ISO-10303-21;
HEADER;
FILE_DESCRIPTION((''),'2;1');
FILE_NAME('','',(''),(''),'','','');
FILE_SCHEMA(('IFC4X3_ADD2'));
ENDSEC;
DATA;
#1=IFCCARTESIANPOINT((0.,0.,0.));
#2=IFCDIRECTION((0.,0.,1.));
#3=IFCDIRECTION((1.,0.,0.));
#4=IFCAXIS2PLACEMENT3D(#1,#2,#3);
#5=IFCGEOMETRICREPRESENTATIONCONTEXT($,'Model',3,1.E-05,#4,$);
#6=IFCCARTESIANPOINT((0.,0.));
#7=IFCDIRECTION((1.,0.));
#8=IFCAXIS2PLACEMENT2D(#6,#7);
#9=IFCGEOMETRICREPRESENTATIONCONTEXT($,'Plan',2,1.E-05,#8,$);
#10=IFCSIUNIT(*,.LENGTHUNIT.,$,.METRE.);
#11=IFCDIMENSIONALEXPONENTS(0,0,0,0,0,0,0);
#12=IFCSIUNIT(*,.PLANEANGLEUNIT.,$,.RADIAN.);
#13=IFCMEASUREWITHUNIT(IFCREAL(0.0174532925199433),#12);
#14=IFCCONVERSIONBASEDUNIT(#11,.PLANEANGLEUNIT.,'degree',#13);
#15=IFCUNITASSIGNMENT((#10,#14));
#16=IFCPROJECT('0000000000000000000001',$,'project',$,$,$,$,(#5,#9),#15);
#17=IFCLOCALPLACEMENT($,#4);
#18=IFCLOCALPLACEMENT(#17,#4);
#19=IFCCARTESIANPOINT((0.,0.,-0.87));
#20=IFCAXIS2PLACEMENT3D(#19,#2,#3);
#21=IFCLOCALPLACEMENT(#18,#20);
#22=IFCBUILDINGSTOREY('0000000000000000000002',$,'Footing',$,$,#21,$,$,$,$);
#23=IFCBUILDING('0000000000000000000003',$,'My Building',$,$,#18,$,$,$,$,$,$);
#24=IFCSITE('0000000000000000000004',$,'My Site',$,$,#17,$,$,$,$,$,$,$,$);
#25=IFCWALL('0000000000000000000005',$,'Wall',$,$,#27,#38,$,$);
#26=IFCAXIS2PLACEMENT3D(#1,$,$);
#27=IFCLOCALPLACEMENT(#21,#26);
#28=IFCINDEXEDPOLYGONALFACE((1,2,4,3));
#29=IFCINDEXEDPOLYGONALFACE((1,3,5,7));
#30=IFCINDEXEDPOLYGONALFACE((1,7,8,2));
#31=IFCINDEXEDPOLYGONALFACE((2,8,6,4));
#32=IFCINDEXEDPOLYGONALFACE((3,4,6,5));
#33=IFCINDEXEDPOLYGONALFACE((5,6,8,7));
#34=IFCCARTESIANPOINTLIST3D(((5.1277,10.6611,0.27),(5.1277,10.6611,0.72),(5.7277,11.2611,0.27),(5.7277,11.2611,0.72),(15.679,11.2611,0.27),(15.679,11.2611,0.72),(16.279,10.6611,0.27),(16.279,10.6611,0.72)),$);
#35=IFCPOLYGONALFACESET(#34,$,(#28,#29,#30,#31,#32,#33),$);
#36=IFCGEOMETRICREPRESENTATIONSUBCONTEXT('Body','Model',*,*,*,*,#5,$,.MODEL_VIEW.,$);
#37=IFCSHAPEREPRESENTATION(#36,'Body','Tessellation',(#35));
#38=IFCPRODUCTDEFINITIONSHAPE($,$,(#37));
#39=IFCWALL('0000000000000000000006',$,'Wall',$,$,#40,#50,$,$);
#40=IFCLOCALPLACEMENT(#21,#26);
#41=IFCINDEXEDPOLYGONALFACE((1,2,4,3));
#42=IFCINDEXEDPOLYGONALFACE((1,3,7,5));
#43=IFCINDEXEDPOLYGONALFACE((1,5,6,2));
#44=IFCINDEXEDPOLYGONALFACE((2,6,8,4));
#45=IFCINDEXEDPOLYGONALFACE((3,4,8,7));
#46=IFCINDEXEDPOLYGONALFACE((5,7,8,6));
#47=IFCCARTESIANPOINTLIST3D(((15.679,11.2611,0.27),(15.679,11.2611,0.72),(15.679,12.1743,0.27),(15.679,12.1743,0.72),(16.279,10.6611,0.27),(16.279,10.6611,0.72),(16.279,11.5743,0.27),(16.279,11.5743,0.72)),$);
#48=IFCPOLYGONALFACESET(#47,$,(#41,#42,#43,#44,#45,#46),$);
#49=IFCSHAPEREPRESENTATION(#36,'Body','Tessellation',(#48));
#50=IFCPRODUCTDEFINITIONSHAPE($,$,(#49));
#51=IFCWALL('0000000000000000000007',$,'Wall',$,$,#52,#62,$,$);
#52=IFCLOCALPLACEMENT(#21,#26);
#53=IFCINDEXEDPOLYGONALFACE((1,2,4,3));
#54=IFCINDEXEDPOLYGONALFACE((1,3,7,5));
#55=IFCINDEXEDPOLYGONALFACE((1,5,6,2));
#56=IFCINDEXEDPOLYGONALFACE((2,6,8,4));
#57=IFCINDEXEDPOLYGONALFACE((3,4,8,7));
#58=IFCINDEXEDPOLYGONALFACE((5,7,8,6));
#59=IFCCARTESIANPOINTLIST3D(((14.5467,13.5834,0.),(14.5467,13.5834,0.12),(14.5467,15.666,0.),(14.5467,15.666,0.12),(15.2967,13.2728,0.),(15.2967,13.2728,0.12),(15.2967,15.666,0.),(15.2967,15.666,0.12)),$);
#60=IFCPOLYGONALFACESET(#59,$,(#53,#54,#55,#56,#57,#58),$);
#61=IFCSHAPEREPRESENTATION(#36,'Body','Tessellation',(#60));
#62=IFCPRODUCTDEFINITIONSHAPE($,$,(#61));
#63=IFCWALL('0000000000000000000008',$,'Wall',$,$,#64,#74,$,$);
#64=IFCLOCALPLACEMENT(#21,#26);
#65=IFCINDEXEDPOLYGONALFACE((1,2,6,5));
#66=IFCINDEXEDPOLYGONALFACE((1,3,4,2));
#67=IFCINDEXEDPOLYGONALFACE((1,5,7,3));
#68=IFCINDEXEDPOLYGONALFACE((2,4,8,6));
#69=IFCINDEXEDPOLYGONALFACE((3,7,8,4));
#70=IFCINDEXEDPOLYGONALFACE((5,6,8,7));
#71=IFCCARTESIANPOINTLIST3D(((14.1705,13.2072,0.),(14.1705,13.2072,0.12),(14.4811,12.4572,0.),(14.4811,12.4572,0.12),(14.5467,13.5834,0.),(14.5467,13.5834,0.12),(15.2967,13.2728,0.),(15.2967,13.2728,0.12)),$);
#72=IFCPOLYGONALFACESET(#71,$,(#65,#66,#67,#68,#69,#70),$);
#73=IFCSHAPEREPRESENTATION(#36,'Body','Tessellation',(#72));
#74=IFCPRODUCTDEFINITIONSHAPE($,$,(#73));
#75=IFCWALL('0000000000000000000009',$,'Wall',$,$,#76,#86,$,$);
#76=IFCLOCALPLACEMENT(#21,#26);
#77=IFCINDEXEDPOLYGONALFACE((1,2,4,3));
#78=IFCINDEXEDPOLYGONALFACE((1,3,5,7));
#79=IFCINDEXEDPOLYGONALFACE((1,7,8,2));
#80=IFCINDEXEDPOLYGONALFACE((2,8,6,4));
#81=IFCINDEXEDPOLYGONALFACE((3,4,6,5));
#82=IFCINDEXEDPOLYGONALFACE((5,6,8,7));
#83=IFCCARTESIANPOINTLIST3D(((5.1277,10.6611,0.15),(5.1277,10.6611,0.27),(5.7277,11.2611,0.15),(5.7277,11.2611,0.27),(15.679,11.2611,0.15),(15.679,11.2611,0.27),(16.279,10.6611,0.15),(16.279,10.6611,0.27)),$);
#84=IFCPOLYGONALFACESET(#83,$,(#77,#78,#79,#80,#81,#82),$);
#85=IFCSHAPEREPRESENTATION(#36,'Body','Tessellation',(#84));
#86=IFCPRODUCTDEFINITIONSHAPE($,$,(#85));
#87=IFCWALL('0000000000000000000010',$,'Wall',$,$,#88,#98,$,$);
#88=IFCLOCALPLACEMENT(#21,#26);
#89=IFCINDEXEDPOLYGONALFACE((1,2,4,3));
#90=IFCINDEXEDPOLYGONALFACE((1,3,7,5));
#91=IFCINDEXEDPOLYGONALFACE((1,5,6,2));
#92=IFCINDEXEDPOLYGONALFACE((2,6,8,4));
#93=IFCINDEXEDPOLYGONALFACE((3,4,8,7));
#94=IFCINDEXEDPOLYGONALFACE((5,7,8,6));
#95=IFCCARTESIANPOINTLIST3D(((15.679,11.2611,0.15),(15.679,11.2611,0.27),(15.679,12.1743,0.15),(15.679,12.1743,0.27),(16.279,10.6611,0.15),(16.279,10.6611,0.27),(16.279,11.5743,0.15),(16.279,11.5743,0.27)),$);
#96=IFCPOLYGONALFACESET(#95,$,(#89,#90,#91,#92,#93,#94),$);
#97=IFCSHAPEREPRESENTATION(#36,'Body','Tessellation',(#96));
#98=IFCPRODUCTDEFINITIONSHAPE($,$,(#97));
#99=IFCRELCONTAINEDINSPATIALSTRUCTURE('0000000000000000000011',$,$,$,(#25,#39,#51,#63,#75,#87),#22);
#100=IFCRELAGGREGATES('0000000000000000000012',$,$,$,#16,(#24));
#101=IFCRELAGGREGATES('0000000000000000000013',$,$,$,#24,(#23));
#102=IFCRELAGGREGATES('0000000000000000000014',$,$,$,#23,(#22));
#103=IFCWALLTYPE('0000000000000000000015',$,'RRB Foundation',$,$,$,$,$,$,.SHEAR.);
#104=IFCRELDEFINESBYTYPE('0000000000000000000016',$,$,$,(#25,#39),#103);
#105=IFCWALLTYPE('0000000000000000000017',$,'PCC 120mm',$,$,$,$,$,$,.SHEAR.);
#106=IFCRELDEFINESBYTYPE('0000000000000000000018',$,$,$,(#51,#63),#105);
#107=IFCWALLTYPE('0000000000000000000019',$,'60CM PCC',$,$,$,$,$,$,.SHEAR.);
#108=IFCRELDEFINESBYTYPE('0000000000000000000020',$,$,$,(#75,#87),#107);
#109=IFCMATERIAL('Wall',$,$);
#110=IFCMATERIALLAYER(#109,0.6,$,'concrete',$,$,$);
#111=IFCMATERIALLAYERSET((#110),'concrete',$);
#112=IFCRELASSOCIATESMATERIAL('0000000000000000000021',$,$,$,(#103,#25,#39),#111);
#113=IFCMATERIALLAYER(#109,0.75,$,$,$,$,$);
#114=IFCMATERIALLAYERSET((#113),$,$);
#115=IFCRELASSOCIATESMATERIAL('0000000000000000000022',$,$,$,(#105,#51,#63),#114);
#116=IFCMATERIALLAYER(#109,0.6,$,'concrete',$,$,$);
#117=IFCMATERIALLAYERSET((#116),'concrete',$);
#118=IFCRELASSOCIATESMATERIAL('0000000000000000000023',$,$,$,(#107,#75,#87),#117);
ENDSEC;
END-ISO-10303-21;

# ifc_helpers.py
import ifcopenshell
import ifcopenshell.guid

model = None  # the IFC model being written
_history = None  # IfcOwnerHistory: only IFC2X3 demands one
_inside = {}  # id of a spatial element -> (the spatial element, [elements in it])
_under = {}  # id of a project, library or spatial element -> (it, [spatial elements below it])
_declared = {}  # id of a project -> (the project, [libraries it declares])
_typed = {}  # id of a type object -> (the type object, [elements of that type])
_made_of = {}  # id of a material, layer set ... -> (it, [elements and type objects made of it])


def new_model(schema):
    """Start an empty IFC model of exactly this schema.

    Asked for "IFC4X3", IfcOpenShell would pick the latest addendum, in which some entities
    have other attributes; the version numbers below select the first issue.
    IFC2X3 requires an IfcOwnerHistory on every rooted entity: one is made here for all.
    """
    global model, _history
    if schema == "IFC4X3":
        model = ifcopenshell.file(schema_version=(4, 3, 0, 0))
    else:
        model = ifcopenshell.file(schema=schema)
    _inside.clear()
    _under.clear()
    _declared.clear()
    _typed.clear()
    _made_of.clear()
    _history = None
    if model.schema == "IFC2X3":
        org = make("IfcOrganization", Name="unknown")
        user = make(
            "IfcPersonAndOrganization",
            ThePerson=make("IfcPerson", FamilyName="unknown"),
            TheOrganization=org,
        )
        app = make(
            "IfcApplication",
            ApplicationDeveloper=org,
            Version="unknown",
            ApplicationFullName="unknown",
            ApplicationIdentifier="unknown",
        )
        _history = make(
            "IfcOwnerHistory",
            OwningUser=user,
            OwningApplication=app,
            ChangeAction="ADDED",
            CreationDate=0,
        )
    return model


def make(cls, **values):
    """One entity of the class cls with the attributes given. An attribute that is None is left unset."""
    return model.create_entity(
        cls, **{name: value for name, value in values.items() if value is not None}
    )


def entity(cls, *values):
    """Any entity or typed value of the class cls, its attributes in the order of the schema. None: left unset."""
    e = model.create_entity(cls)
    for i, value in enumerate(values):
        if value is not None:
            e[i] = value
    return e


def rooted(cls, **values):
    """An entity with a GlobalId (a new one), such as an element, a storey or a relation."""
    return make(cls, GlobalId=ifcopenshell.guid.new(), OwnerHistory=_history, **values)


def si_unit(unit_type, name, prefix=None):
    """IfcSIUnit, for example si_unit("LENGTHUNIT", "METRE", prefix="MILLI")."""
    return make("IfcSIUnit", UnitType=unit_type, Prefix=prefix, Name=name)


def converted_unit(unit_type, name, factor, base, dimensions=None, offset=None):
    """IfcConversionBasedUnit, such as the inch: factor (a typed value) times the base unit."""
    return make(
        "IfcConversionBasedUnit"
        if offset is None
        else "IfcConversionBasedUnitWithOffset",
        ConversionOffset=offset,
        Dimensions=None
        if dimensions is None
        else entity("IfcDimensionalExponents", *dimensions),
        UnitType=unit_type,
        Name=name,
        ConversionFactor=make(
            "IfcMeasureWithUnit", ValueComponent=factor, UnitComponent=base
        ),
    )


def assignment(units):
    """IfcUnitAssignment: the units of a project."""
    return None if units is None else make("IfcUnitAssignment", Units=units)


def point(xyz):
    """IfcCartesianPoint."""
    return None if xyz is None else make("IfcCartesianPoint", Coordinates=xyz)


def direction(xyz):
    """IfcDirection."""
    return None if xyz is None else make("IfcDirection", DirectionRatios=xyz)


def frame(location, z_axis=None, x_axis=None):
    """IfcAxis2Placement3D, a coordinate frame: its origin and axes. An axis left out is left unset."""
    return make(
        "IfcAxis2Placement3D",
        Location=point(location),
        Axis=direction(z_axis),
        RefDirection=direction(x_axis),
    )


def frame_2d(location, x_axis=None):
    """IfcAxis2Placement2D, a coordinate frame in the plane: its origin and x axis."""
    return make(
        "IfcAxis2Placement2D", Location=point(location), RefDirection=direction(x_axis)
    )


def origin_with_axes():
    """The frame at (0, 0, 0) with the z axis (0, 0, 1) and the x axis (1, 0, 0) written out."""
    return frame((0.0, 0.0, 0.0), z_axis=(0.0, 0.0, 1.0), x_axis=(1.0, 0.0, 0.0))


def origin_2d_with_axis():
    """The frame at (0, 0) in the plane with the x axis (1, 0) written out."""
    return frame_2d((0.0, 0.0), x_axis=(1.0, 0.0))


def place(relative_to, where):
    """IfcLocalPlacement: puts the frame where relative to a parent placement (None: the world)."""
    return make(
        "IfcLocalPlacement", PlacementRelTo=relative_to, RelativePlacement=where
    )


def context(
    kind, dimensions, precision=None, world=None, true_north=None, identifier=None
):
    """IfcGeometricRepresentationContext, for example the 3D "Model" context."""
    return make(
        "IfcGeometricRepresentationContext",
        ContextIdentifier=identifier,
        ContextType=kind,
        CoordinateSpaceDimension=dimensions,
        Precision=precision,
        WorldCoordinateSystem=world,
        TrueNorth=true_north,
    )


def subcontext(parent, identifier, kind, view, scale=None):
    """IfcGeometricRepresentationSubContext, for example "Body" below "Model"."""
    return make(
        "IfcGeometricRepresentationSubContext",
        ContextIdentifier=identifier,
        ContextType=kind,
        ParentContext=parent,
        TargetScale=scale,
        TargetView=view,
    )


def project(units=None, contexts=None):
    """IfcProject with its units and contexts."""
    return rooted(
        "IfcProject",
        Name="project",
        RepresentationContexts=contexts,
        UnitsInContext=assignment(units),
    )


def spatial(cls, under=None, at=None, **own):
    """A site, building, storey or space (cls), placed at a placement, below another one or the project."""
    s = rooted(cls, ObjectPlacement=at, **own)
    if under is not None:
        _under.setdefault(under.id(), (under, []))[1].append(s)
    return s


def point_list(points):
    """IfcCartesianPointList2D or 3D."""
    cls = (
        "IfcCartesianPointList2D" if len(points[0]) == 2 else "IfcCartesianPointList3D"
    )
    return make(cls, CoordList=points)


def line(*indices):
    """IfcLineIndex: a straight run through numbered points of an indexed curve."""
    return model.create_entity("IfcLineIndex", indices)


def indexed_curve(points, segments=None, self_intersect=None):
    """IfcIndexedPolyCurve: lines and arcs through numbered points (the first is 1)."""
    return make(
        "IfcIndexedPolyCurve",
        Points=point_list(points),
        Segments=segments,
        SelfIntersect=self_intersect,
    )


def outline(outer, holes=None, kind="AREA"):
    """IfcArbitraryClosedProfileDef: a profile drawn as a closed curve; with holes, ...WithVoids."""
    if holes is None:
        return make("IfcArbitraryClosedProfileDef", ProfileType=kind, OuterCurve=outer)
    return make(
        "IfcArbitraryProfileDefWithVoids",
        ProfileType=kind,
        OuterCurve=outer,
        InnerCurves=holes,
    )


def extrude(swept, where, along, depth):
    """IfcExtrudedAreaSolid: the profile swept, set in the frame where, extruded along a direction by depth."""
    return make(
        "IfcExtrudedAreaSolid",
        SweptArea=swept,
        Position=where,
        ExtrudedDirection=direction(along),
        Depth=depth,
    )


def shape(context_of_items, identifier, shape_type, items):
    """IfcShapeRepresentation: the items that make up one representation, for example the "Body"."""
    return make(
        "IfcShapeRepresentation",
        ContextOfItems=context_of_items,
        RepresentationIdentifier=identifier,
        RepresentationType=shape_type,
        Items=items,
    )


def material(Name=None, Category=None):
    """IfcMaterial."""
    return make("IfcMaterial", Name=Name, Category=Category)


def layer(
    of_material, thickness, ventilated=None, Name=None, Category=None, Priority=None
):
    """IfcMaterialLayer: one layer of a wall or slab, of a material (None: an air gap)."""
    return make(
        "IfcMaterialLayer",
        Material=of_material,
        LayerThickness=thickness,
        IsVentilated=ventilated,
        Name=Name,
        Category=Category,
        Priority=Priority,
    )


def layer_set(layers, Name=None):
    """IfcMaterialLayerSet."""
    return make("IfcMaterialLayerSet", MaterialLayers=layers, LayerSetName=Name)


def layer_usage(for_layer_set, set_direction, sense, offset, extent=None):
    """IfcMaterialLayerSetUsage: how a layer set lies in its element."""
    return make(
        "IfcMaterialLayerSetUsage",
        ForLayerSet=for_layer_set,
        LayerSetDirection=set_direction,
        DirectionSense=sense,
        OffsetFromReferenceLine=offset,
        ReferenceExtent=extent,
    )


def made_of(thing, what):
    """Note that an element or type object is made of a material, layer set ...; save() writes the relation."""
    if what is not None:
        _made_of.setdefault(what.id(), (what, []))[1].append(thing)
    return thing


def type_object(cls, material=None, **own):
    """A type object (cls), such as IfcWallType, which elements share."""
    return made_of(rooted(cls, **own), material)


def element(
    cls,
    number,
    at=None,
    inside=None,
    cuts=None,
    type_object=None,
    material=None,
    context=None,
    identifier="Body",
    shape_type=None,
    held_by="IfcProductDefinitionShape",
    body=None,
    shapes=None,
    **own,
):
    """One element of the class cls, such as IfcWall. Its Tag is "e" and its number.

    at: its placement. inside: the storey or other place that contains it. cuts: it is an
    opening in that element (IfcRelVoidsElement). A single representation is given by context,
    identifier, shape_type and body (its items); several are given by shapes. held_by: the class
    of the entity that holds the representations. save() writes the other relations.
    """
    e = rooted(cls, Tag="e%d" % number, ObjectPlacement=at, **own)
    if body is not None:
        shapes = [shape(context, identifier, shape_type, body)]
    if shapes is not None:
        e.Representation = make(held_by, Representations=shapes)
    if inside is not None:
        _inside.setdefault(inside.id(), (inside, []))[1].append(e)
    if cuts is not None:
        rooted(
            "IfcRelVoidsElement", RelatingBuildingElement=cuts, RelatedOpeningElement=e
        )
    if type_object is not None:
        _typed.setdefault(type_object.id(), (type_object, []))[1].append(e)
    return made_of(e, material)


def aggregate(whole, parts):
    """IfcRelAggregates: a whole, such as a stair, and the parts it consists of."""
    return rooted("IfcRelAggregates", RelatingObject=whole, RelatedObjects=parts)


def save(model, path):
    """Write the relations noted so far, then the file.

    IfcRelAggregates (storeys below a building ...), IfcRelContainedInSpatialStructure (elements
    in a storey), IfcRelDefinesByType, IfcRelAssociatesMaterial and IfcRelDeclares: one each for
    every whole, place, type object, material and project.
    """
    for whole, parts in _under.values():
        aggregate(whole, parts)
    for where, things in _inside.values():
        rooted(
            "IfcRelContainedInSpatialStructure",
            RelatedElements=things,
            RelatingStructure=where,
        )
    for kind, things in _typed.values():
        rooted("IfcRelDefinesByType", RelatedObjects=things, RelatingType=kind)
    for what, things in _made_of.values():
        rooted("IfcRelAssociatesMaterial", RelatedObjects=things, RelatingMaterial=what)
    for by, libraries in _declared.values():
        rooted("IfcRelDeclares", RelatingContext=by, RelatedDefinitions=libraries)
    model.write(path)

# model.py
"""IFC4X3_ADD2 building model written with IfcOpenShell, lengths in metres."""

from ifc_helpers import new_model, entity, si_unit, converted_unit, frame, origin_with_axes, origin_2d_with_axis, place, context, subcontext, project, spatial, line, indexed_curve, outline, extrude, material, layer, layer_set, layer_usage, type_object, element, save


model = new_model("IFC4X3_ADD2")

# Units and contexts
model_context = context("Model", 3, precision=1e-05, world=origin_with_axes())
plan_context = context("Plan", 2, precision=1e-05, world=origin_2d_with_axis())
body_context = subcontext(model_context, "Body", "Model", "MODEL_VIEW")
ifc_project = project(units=[si_unit("LENGTHUNIT", "METRE"), converted_unit("PLANEANGLEUNIT", "degree", entity("IfcReal", 0.0174532925199433), si_unit("PLANEANGLEUNIT", "RADIAN"), dimensions=[0, 0, 0, 0, 0, 0, 0])], contexts=[model_context, plan_context])

# Site, building, storey
site_placement = place(None, origin_with_axes())
site = spatial("IfcSite", under=ifc_project, at=site_placement, Name="My Site")
building_placement = place(site_placement, origin_with_axes())
building = spatial("IfcBuilding", under=site, at=building_placement, Name="My Building")
storey_placement = place(building_placement, frame((0.0, 0.0, -0.87), z_axis=(0.0, 0.0, 1.0), x_axis=(1.0, 0.0, 0.0)))
storey = spatial("IfcBuildingStorey", under=building, at=storey_placement, Name="Footing")

# Walls
ifc_material_1 = material(Name="Wall")
ifc_layer_1 = layer(ifc_material_1, 0.6, Name="concrete")
ifc_layer_set_1 = layer_set([ifc_layer_1], Name="concrete")
wall_type_1 = type_object("IfcWallType", Name="RRB Foundation", PredefinedType="SHEAR", material=ifc_layer_set_1)
ifc_layer_usage_1 = layer_usage(ifc_layer_set_1, "AXIS2", "POSITIVE", 0.0)
wall_1_placement = place(storey_placement, frame((15.679, 11.2611, 0.27), z_axis=(0.0, 0.0, 1.0), x_axis=(-1.0, 0.0, 0.0)))
element("IfcWall", 1, at=wall_1_placement, inside=storey, type_object=wall_type_1, material=ifc_layer_usage_1, Name="Wall", context=body_context, shape_type="SweptSolid", body=[
    extrude(outline(indexed_curve([(0.0, 0.0), (-0.6, 0.6), (10.5513, 0.6), (9.9513, 0.0)], segments=[line(1, 2, 3, 4, 1)])), origin_with_axes(), (0.0, 0.0, 1.0), 0.45),
])
ifc_layer_usage_2 = layer_usage(ifc_layer_set_1, "AXIS2", "POSITIVE", 0.0)
wall_2_placement = place(storey_placement, frame((15.679, 12.1743, 0.27), z_axis=(0.0, 0.0, 1.0), x_axis=(-0.000001, -1.0, 0.0)))
element("IfcWall", 2, at=wall_2_placement, inside=storey, type_object=wall_type_1, material=ifc_layer_usage_2, Name="Wall", context=body_context, shape_type="SweptSolid", body=[
    extrude(outline(indexed_curve([(0.0, 0.0), (0.6, 0.6), (1.5132, 0.6), (0.9132, 0.0)], segments=[line(1, 2, 3, 4, 1)])), origin_with_axes(), (0.0, 0.0, 1.0), 0.45),
])
ifc_layer_2 = layer(ifc_material_1, 0.75)
ifc_layer_set_2 = layer_set([ifc_layer_2])
ifc_layer_usage_3 = layer_usage(ifc_layer_set_2, "AXIS2", "POSITIVE", 0.0)
wall_type_2 = type_object("IfcWallType", Name="PCC 120mm", PredefinedType="SHEAR", material=ifc_layer_set_2)
wall_3_placement = place(storey_placement, frame((15.2967, 13.2728, 0.0), z_axis=(0.0, 0.0, 1.0), x_axis=(0.0, 1.0, 0.0)))
element("IfcWall", 3, at=wall_3_placement, inside=storey, type_object=wall_type_2, material=ifc_layer_usage_3, Name="Wall", context=body_context, shape_type="SweptSolid", body=[
    extrude(outline(indexed_curve([(0.0, 0.0), (0.3107, 0.75), (2.3932, 0.75), (2.3932, 0.0)], segments=[line(1, 2, 3, 4, 1)])), origin_with_axes(), (0.0, 0.0, 1.0), 0.12),
])
ifc_layer_usage_4 = layer_usage(ifc_layer_set_2, "AXIS2", "POSITIVE", 0.0)
wall_4_placement = place(storey_placement, frame((14.4811, 12.4572, 0.0), z_axis=(0.0, 0.0, 1.0), x_axis=(0.707107, 0.707107, 0.0)))
element("IfcWall", 4, at=wall_4_placement, inside=storey, type_object=wall_type_2, material=ifc_layer_usage_4, Name="Wall", context=body_context, shape_type="SweptSolid", body=[
    extrude(outline(indexed_curve([(0.0, 0.0), (0.3107, 0.75), (0.8427, 0.75), (1.1534, 0.0)], segments=[line(1, 2, 3, 4, 1)])), origin_with_axes(), (0.0, 0.0, 1.0), 0.12),
])
ifc_layer_3 = layer(ifc_material_1, 0.6, Name="concrete")
ifc_layer_set_3 = layer_set([ifc_layer_3], Name="concrete")
ifc_layer_usage_5 = layer_usage(ifc_layer_set_3, "AXIS2", "POSITIVE", 0.0)
wall_type_3 = type_object("IfcWallType", Name="60CM PCC", PredefinedType="SHEAR", material=ifc_layer_set_3)
wall_5_placement = place(storey_placement, frame((15.679, 11.2611, 0.15), z_axis=(0.0, 0.0, 1.0), x_axis=(-1.0, 0.0, 0.0)))
element("IfcWall", 5, at=wall_5_placement, inside=storey, type_object=wall_type_3, material=ifc_layer_usage_5, Name="Wall", context=body_context, shape_type="SweptSolid", body=[
    extrude(outline(indexed_curve([(0.0, 0.0), (-0.6, 0.6), (10.5513, 0.6), (9.9513, 0.0)], segments=[line(1, 2, 3, 4, 1)])), origin_with_axes(), (0.0, 0.0, 1.0), 0.12),
])
ifc_layer_usage_6 = layer_usage(ifc_layer_set_3, "AXIS2", "POSITIVE", 0.0)
wall_6_placement = place(storey_placement, frame((15.679, 12.1743, 0.15), z_axis=(0.0, 0.0, 1.0), x_axis=(-0.000001, -1.0, 0.0)))
element("IfcWall", 6, at=wall_6_placement, inside=storey, type_object=wall_type_3, material=ifc_layer_usage_6, Name="Wall", context=body_context, shape_type="SweptSolid", body=[
    extrude(outline(indexed_curve([(0.0, 0.0), (0.6, 0.6), (1.5132, 0.6), (0.9132, 0.0)], segments=[line(1, 2, 3, 4, 1)])), origin_with_axes(), (0.0, 0.0, 1.0), 0.12),
])

save(model, "model.ifc")
